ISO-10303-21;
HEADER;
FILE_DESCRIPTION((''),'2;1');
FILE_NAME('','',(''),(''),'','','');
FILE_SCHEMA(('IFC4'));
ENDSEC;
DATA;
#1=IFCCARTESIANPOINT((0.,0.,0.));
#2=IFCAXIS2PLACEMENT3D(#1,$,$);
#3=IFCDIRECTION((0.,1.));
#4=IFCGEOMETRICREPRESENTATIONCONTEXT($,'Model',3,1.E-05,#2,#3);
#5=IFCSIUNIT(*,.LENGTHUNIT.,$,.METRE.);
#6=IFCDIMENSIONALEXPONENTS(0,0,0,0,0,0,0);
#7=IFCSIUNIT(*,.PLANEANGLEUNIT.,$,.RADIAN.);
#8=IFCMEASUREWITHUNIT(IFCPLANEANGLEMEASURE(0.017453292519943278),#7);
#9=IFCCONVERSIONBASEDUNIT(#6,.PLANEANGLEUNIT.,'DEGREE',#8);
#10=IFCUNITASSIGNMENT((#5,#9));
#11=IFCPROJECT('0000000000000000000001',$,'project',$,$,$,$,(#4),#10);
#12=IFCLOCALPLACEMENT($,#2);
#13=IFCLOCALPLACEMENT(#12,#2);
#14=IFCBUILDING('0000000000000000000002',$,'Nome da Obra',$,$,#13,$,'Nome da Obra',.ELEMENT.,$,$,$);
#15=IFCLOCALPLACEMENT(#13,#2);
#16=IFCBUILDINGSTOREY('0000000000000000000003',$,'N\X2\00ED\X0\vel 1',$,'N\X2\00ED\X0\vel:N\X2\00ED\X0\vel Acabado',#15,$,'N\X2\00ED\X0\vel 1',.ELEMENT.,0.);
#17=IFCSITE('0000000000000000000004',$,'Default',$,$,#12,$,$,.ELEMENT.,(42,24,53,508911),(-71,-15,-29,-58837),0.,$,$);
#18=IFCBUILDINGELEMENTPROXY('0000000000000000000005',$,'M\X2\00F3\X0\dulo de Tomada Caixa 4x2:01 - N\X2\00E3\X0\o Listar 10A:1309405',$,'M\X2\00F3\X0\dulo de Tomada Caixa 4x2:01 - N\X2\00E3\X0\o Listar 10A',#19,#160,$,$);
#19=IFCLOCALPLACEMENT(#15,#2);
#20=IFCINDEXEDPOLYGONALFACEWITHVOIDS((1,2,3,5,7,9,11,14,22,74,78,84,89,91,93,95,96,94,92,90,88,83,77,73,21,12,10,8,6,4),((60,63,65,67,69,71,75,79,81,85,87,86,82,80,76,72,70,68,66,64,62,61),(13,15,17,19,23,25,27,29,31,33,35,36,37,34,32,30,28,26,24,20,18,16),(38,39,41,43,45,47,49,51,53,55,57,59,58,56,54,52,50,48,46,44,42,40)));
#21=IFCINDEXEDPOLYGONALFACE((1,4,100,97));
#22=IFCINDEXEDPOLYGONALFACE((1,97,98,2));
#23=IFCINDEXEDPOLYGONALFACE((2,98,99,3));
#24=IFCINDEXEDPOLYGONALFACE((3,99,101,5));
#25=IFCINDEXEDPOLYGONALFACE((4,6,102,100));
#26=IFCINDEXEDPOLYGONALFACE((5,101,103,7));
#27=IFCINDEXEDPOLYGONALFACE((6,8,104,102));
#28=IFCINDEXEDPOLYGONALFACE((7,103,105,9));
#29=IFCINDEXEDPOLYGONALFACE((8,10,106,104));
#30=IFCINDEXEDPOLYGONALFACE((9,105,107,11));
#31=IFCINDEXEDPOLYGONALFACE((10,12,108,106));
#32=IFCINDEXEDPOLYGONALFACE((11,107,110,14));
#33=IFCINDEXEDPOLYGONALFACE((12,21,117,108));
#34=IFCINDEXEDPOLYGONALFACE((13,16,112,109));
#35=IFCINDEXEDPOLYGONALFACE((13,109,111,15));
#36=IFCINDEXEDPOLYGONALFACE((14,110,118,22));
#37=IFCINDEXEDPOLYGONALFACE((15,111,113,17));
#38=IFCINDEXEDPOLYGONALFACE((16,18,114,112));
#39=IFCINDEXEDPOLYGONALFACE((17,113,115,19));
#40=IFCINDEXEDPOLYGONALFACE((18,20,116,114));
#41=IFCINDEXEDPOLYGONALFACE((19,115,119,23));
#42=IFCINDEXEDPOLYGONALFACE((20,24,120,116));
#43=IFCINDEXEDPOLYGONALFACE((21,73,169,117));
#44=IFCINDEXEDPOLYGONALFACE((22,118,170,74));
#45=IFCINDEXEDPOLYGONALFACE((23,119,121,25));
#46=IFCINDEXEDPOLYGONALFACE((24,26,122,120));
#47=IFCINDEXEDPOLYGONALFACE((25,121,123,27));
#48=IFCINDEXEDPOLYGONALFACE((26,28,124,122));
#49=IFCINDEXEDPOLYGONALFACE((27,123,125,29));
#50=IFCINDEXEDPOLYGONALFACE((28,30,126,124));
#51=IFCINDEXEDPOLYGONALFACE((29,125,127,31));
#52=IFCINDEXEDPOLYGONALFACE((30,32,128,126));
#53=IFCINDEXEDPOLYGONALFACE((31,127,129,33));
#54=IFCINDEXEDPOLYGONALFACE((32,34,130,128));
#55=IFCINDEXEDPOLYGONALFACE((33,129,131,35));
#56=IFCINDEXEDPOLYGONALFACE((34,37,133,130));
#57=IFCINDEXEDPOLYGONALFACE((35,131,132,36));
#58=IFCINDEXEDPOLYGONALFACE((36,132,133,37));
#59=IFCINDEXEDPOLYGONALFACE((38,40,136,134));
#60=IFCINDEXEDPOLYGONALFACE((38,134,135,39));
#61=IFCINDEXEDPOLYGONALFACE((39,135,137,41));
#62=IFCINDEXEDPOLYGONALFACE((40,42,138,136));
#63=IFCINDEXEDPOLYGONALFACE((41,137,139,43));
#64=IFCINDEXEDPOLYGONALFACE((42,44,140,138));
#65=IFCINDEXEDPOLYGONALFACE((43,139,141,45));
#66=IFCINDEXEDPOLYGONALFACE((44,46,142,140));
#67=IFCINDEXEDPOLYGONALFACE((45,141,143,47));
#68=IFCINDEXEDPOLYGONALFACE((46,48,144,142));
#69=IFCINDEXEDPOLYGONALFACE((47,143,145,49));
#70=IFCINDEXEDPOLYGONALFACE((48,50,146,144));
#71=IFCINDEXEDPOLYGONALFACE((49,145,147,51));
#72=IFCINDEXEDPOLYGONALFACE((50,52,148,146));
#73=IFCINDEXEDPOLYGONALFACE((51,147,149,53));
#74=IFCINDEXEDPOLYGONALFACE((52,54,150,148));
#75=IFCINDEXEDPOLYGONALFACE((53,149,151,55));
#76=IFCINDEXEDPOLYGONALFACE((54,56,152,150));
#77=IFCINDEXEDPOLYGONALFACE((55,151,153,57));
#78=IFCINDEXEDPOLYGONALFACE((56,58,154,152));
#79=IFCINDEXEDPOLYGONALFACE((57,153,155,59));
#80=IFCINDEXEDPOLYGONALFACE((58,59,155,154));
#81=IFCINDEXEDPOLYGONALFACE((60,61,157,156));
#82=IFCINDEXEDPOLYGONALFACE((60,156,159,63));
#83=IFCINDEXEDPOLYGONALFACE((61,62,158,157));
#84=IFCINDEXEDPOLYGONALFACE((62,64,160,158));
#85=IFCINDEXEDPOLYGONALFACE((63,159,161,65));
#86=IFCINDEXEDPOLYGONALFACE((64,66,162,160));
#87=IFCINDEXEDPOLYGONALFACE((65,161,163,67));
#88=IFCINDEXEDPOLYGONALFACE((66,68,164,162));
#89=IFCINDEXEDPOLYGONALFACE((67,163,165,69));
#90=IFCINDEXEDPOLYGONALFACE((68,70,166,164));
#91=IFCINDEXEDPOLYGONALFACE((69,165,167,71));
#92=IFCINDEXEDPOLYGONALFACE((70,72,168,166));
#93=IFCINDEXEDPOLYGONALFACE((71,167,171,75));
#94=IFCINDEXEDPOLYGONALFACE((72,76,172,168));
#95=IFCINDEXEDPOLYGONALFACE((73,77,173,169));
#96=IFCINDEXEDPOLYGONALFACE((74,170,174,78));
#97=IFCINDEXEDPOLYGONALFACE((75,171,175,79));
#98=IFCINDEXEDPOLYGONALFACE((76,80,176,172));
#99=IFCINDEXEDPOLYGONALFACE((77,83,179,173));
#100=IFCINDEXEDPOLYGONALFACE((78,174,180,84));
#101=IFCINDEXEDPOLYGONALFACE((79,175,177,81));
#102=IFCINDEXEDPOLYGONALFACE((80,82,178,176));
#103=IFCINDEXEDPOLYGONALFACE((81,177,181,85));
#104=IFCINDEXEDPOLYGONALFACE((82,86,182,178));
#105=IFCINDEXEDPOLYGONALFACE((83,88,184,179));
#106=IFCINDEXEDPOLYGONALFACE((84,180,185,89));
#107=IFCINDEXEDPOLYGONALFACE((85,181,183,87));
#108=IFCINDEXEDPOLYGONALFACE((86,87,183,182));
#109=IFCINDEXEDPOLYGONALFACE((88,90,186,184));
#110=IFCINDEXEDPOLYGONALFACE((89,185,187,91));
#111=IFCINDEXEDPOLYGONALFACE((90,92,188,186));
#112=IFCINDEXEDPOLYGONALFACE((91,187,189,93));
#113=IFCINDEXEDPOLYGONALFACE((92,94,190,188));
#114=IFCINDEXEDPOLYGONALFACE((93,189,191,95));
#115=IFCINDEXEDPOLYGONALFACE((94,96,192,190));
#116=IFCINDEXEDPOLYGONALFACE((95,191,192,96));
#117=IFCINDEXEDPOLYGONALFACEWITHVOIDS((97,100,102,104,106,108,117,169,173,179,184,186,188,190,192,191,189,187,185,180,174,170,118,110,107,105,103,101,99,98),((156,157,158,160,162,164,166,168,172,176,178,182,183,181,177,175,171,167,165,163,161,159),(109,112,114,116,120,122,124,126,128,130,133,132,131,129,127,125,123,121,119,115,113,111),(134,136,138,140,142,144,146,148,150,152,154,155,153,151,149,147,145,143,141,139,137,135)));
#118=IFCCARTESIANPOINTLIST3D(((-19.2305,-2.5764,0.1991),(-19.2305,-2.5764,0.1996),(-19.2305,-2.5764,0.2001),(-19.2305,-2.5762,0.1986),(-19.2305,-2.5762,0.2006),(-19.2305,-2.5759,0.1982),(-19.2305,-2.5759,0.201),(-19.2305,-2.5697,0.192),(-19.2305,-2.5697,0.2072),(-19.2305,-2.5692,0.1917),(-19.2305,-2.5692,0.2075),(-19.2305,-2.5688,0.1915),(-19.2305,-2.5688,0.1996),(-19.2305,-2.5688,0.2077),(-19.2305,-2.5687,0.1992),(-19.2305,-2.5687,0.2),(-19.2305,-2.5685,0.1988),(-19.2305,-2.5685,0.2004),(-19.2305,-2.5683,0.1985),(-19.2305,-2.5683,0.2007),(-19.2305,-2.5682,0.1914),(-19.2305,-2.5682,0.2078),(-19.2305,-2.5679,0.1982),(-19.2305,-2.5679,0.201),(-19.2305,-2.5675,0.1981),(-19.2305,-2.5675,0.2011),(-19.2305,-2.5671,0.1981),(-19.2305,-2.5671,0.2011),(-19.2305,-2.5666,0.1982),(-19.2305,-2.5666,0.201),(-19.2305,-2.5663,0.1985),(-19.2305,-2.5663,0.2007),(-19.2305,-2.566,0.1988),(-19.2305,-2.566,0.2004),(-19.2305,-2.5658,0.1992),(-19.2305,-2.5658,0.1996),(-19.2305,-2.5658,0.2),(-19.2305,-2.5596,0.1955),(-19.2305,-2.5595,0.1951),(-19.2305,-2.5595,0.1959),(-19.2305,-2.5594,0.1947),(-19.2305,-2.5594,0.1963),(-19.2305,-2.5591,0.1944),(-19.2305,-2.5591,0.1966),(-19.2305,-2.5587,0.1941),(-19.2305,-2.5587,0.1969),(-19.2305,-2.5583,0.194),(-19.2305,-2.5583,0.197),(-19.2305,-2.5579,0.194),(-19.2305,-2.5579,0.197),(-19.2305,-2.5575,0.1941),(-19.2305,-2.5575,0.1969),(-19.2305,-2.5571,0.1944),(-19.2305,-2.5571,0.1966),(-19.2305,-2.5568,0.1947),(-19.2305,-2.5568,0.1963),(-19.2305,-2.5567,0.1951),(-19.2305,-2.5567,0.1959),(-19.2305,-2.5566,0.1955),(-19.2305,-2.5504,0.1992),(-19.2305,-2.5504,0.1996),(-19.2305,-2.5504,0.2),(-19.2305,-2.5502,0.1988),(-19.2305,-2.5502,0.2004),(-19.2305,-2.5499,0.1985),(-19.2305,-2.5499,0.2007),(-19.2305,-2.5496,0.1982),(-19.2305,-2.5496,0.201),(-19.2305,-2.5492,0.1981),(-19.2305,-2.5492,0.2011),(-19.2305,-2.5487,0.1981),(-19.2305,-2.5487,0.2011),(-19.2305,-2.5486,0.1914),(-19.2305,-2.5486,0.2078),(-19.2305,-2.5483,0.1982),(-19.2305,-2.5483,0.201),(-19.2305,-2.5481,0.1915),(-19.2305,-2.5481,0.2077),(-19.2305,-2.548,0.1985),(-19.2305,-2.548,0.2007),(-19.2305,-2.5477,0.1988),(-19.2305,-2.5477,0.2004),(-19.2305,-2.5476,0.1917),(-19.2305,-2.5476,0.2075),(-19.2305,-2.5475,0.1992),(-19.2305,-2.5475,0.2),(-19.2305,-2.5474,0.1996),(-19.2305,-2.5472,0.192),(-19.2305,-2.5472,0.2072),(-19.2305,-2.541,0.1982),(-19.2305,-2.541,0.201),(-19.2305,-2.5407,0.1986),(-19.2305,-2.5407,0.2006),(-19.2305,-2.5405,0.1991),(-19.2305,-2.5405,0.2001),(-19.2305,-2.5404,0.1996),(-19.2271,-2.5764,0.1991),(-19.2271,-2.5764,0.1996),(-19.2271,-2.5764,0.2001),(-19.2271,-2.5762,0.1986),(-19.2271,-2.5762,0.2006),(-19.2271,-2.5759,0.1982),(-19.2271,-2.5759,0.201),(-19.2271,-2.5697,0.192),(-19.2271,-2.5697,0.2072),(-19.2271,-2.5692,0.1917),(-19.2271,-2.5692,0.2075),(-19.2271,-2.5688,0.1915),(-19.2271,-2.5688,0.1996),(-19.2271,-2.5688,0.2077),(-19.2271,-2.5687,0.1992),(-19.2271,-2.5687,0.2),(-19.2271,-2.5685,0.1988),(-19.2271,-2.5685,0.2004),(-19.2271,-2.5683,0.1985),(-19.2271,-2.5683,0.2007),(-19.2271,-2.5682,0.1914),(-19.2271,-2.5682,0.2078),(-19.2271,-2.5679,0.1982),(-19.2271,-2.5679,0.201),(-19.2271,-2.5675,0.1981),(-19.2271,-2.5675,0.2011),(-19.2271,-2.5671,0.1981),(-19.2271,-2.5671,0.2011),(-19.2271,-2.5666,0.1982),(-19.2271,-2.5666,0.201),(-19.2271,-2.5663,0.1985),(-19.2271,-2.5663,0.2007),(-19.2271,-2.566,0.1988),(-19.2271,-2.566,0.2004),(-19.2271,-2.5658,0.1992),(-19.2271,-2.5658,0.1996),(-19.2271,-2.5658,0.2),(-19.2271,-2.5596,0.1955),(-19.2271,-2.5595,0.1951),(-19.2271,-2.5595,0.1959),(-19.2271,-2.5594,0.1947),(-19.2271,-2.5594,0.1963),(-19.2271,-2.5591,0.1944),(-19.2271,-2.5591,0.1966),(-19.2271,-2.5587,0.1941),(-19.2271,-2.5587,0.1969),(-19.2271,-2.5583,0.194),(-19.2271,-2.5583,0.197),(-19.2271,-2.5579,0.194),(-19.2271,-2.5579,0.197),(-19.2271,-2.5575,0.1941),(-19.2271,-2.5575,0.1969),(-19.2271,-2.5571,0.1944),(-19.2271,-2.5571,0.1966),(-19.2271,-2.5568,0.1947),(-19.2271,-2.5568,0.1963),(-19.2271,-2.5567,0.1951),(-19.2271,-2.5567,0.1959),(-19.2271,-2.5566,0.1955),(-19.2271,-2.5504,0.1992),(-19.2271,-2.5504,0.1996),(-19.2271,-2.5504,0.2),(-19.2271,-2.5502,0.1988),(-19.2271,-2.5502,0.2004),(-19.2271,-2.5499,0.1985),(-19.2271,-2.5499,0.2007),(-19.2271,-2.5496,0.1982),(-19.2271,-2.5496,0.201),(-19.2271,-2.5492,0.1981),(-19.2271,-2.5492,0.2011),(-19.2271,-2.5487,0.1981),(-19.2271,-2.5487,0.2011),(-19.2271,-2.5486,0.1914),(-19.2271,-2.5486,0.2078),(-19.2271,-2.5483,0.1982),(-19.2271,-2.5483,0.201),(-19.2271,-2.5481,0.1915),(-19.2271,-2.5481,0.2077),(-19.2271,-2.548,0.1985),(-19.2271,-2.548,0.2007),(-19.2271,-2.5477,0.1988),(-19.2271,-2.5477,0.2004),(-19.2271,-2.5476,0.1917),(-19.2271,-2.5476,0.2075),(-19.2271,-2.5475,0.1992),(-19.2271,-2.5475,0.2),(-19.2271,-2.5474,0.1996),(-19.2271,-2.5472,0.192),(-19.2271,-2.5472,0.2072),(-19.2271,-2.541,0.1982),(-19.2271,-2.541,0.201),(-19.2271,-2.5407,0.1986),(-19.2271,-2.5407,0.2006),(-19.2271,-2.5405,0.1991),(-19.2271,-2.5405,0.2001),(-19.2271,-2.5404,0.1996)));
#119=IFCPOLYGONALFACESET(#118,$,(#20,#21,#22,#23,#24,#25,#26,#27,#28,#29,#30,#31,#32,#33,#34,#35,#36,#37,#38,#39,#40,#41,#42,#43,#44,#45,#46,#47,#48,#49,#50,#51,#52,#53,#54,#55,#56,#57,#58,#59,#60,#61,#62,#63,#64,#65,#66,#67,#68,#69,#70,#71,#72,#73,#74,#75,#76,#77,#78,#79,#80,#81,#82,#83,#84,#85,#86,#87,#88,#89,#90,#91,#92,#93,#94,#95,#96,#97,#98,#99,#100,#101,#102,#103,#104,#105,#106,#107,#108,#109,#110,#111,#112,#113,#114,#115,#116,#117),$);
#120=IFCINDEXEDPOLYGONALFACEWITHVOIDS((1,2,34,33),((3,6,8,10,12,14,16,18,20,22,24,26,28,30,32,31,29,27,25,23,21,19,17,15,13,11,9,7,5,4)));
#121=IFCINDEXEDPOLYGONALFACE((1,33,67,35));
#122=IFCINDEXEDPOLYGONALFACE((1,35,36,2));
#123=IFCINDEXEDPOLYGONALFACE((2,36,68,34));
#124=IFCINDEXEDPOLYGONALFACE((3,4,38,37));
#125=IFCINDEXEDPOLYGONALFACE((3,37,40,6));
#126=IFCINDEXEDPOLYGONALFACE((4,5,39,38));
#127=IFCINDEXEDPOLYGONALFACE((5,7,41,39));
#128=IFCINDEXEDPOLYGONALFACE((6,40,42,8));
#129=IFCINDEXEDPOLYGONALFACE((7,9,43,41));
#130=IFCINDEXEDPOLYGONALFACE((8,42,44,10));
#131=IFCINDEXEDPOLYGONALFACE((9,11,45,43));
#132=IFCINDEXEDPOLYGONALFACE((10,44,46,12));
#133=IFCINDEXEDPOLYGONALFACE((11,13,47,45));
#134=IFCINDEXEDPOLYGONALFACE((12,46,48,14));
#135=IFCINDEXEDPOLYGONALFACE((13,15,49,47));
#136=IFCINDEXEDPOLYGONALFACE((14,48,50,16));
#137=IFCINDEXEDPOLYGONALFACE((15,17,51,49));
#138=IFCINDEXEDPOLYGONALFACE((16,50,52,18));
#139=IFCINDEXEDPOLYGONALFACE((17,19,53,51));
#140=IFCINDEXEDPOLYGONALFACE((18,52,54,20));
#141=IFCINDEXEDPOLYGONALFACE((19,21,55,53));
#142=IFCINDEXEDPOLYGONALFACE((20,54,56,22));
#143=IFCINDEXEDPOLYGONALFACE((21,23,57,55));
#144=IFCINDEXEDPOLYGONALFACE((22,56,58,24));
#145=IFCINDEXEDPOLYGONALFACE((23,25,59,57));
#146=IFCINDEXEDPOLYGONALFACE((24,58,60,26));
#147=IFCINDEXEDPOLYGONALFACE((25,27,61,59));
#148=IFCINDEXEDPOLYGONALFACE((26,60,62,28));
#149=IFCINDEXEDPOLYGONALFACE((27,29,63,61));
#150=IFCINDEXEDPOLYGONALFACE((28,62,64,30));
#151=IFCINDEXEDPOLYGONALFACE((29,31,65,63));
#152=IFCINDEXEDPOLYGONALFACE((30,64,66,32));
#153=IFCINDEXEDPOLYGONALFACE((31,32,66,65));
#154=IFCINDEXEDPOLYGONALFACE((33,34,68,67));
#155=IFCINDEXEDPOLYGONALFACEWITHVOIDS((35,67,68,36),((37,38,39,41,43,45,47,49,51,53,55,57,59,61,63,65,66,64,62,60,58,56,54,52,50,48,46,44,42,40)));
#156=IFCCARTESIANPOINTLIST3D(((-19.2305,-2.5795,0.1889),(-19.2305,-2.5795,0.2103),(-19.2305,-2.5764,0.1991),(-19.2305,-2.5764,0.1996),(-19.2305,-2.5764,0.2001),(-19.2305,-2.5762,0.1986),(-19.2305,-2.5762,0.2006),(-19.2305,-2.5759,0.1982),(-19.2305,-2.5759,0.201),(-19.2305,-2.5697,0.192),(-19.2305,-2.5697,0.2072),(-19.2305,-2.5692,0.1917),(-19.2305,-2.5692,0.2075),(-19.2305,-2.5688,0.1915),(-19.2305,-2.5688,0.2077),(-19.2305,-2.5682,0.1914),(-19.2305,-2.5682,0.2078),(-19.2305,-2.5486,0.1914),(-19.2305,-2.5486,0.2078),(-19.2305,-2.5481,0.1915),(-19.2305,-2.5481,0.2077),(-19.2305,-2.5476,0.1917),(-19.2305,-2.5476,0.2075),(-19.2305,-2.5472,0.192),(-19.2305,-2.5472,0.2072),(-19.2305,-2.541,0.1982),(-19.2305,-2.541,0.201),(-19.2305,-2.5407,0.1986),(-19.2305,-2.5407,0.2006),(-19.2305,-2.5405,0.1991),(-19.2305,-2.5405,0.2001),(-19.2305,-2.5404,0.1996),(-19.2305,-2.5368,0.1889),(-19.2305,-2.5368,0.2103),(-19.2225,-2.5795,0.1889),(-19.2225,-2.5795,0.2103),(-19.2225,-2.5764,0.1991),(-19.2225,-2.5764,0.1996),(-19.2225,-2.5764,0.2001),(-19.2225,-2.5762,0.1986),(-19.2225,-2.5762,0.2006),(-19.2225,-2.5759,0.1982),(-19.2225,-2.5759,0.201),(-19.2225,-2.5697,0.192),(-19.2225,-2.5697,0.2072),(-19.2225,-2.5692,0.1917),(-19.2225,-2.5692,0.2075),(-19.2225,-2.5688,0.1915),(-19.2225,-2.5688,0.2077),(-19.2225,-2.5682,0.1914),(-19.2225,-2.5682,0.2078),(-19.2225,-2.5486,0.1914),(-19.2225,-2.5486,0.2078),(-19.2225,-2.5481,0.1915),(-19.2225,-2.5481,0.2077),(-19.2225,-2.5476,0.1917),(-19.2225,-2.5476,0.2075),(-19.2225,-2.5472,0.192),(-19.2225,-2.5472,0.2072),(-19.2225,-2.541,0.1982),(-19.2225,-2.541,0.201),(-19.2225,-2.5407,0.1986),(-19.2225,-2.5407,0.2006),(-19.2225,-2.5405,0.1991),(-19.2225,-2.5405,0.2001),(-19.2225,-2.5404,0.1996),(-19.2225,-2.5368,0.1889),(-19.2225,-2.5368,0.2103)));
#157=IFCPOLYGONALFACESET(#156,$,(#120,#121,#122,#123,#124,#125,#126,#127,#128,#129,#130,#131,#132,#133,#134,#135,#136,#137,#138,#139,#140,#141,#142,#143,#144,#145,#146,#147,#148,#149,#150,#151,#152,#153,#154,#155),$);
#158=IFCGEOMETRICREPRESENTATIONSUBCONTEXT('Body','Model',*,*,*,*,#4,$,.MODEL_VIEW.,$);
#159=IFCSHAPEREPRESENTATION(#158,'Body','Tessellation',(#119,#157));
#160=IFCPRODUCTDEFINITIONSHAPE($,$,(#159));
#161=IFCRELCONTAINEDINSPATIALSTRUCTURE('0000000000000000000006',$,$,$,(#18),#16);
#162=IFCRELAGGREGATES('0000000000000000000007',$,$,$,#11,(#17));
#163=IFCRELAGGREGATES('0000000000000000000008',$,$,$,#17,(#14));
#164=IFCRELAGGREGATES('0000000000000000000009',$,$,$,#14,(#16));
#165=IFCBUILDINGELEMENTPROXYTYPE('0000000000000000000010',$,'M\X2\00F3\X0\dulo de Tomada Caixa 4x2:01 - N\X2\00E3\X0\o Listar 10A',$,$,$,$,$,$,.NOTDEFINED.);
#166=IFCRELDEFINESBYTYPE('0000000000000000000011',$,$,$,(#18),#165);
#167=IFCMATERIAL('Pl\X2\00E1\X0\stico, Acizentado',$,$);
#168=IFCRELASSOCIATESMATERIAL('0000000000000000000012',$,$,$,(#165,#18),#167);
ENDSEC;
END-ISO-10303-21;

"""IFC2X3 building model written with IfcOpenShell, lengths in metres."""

from ifc_helpers import new_model, entity, si_unit, converted_unit, direction, frame, frame_2d, origin, place, context, subcontext, project, spatial, polyline, circle_curve, parameter, trimmed, segment, composite_curve, outline, extrude, source, transform, mapped, material, type_object, type_shapes, element, save


model = new_model("IFC2X3")

# Units and contexts
model_context = context("Model", 3, precision=1e-05, world=origin(), true_north=direction((0.0, 1.0)))
body_context = subcontext(model_context, "Body", "Model", "MODEL_VIEW")
ifc_project = project(units=[si_unit("LENGTHUNIT", "METRE"), converted_unit("PLANEANGLEUNIT", "DEGREE", entity("IfcPlaneAngleMeasure", 0.017453292519943278), si_unit("PLANEANGLEUNIT", "RADIAN"), dimensions=[0, 0, 0, 0, 0, 0, 0])], contexts=[model_context])

# Site, building, storey
site_placement = place(None, origin())
site = spatial("IfcSite", under=ifc_project, at=site_placement, Name="Default", CompositionType="ELEMENT", RefLatitude=(42, 24, 53, 508911), RefLongitude=(-71, -15, -29, -58837), RefElevation=0.0)
building_placement = place(site_placement, origin())
building = spatial("IfcBuilding", under=site, at=building_placement, Name="Nome da Obra", LongName="Nome da Obra", CompositionType="ELEMENT")
storey_placement = place(building_placement, origin())
storey = spatial("IfcBuildingStorey", under=building, at=storey_placement, Name="Nível 1", ObjectType="Nível:Nível Acabado", LongName="Nível 1", CompositionType="ELEMENT", Elevation=0.0)

# Building element proxy
ifc_material_1 = material(Name="Plástico, Acizentado")
building_element_proxy_type_1 = type_object("IfcBuildingElementProxyType", Name="Módulo de Tomada Caixa 4x2:01 - Não Listar 10A", PredefinedType="NOTDEFINED", material=ifc_material_1)
shared_shape_1 = source(origin(), body_context, "Body", "SweptSolid", [
    extrude(outline(composite_curve([segment(polyline([(-0.0098, -0.0082), (0.0098, -0.0082)]), True, "CONTINUOUS"), segment(trimmed(circle_curve(frame_2d((0.0098, -0.0062), x_axis=(1.0, 0.0)), 0.002), [parameter(270.0)], [parameter(315.0)], True, "PARAMETER"), True, "CONTINUOUS"), segment(polyline([(0.0112, -0.0076), (0.0174, -0.0014)]), True, "CONTINUOUS"), segment(trimmed(circle_curve(frame_2d((0.016, 0.0), x_axis=(1.0, 0.0)), 0.002), [parameter(315.0)], [parameter(45.0)], True, "PARAMETER"), True, "CONTINUOUS"), segment(polyline([(0.0174, 0.0014), (0.0112, 0.0076)]), True, "CONTINUOUS"), segment(trimmed(circle_curve(frame_2d((0.0098, 0.0062), x_axis=(1.0, 0.0)), 0.002), [parameter(45.0)], [parameter(90.0)], True, "PARAMETER"), True, "CONTINUOUS"), segment(polyline([(0.0098, 0.0082), (-0.0098, 0.0082)]), True, "CONTINUOUS"), segment(trimmed(circle_curve(frame_2d((-0.0098, 0.0062), x_axis=(1.0, 0.0)), 0.002), [parameter(90.0)], [parameter(135.0)], True, "PARAMETER"), True, "CONTINUOUS"), segment(polyline([(-0.0112, 0.0076), (-0.0174, 0.0014)]), True, "CONTINUOUS"), segment(trimmed(circle_curve(frame_2d((-0.016, 0.0), x_axis=(1.0, 0.0)), 0.002), [parameter(135.0)], [parameter(225.0)], True, "PARAMETER"), True, "CONTINUOUS"), segment(polyline([(-0.0174, -0.0014), (-0.0112, -0.0076)]), True, "CONTINUOUS"), segment(trimmed(circle_curve(frame_2d((-0.0098, -0.0062), x_axis=(1.0, 0.0)), 0.002), [parameter(225.0)], [parameter(270.0)], True, "PARAMETER"), True, "CONTINUOUS")], self_intersect=False), holes=[composite_curve([segment(trimmed(circle_curve(frame_2d((0.0089, 0.0), x_axis=(1.0, 0.0)), 0.0015), [parameter(0.0)], [parameter(180.0)], True, "PARAMETER"), False, "CONTINUOUS"), segment(trimmed(circle_curve(frame_2d((0.0089, 0.0), x_axis=(1.0, 0.0)), 0.0015), [parameter(180.0)], [parameter(0.0)], True, "PARAMETER"), False, "CONTINUOUS")], self_intersect=False), composite_curve([segment(trimmed(circle_curve(frame_2d((-0.0003, 0.0041), x_axis=(1.0, 0.0)), 0.0015), [parameter(0.0)], [parameter(180.0)], True, "PARAMETER"), False, "CONTINUOUS"), segment(trimmed(circle_curve(frame_2d((-0.0003, 0.0041), x_axis=(1.0, 0.0)), 0.0015), [parameter(180.0)], [parameter(0.0)], True, "PARAMETER"), False, "CONTINUOUS")], self_intersect=False), composite_curve([segment(trimmed(circle_curve(frame_2d((-0.0095, 0.0), x_axis=(1.0, 0.0)), 0.0015), [parameter(0.0)], [parameter(180.0)], True, "PARAMETER"), False, "CONTINUOUS"), segment(trimmed(circle_curve(frame_2d((-0.0095, 0.0), x_axis=(1.0, 0.0)), 0.0015), [parameter(180.0)], [parameter(0.0)], True, "PARAMETER"), False, "CONTINUOUS")], self_intersect=False)]), frame((0.0003, 0.0, 0.125), z_axis=(0.0, 1.0, 0.0), x_axis=(1.0, 0.0, 0.0)), (0.0, 0.0, 1.0), 0.0034),
    extrude(outline(polyline([(-0.0214, -0.0107), (0.0214, -0.0107), (0.0214, 0.0107), (-0.0214, 0.0107), (-0.0214, -0.0107)]), holes=[composite_curve([segment(polyline([(0.0101, -0.0082), (-0.0095, -0.0082)]), True, "CONTINUOUS"), segment(trimmed(circle_curve(frame_2d((-0.0095, -0.0062), x_axis=(1.0, 0.0)), 0.002), [parameter(225.0)], [parameter(270.0)], True, "PARAMETER"), False, "CONTINUOUS"), segment(polyline([(-0.0109, -0.0076), (-0.0171, -0.0014)]), True, "CONTINUOUS"), segment(trimmed(circle_curve(frame_2d((-0.0157, 0.0), x_axis=(1.0, 0.0)), 0.002), [parameter(135.0)], [parameter(225.0)], True, "PARAMETER"), False, "CONTINUOUS"), segment(polyline([(-0.0171, 0.0014), (-0.0109, 0.0076)]), True, "CONTINUOUS"), segment(trimmed(circle_curve(frame_2d((-0.0095, 0.0062), x_axis=(1.0, 0.0)), 0.002), [parameter(90.0)], [parameter(135.0)], True, "PARAMETER"), False, "CONTINUOUS"), segment(polyline([(-0.0095, 0.0082), (0.0101, 0.0082)]), True, "CONTINUOUS"), segment(trimmed(circle_curve(frame_2d((0.0101, 0.0062), x_axis=(1.0, 0.0)), 0.002), [parameter(45.0)], [parameter(90.0)], True, "PARAMETER"), False, "CONTINUOUS"), segment(polyline([(0.0115, 0.0076), (0.0177, 0.0014)]), True, "CONTINUOUS"), segment(trimmed(circle_curve(frame_2d((0.0163, 0.0), x_axis=(1.0, 0.0)), 0.002), [parameter(315.0)], [parameter(45.0)], True, "PARAMETER"), False, "CONTINUOUS"), segment(polyline([(0.0177, -0.0014), (0.0115, -0.0076)]), True, "CONTINUOUS"), segment(trimmed(circle_curve(frame_2d((0.0101, -0.0062), x_axis=(1.0, 0.0)), 0.002), [parameter(270.0)], [parameter(315.0)], True, "PARAMETER"), False, "CONTINUOUS")], self_intersect=False)]), frame((0.0, 0.0, 0.125), z_axis=(0.0, 1.0, 0.0), x_axis=(1.0, 0.0, 0.0)), (0.0, 0.0, 1.0), 0.008),
])
type_shapes(building_element_proxy_type_1, [shared_shape_1])
for number, where, z_axis, x_axis, name in (
    (1, (-19.2305, -2.5581, 0.0746), (0.0, 0.0, 1.0), (-0.000002, -1.0, 0.0), "Módulo de Tomada Caixa 4x2:01 - Não Listar 10A:1309405"),
):
    element("IfcBuildingElementProxy", number, at=place(storey_placement, frame(where, z_axis=z_axis, x_axis=x_axis)), inside=storey, type_object=building_element_proxy_type_1, material=ifc_material_1, Name=name, ObjectType="Módulo de Tomada Caixa 4x2:01 - Não Listar 10A", context=body_context, shape_type="MappedRepresentation", body=[
        mapped(shared_shape_1, transform((0.0, 0.0, 0.0), scale=1.0)),
    ])

save(model, "model.ifc")
